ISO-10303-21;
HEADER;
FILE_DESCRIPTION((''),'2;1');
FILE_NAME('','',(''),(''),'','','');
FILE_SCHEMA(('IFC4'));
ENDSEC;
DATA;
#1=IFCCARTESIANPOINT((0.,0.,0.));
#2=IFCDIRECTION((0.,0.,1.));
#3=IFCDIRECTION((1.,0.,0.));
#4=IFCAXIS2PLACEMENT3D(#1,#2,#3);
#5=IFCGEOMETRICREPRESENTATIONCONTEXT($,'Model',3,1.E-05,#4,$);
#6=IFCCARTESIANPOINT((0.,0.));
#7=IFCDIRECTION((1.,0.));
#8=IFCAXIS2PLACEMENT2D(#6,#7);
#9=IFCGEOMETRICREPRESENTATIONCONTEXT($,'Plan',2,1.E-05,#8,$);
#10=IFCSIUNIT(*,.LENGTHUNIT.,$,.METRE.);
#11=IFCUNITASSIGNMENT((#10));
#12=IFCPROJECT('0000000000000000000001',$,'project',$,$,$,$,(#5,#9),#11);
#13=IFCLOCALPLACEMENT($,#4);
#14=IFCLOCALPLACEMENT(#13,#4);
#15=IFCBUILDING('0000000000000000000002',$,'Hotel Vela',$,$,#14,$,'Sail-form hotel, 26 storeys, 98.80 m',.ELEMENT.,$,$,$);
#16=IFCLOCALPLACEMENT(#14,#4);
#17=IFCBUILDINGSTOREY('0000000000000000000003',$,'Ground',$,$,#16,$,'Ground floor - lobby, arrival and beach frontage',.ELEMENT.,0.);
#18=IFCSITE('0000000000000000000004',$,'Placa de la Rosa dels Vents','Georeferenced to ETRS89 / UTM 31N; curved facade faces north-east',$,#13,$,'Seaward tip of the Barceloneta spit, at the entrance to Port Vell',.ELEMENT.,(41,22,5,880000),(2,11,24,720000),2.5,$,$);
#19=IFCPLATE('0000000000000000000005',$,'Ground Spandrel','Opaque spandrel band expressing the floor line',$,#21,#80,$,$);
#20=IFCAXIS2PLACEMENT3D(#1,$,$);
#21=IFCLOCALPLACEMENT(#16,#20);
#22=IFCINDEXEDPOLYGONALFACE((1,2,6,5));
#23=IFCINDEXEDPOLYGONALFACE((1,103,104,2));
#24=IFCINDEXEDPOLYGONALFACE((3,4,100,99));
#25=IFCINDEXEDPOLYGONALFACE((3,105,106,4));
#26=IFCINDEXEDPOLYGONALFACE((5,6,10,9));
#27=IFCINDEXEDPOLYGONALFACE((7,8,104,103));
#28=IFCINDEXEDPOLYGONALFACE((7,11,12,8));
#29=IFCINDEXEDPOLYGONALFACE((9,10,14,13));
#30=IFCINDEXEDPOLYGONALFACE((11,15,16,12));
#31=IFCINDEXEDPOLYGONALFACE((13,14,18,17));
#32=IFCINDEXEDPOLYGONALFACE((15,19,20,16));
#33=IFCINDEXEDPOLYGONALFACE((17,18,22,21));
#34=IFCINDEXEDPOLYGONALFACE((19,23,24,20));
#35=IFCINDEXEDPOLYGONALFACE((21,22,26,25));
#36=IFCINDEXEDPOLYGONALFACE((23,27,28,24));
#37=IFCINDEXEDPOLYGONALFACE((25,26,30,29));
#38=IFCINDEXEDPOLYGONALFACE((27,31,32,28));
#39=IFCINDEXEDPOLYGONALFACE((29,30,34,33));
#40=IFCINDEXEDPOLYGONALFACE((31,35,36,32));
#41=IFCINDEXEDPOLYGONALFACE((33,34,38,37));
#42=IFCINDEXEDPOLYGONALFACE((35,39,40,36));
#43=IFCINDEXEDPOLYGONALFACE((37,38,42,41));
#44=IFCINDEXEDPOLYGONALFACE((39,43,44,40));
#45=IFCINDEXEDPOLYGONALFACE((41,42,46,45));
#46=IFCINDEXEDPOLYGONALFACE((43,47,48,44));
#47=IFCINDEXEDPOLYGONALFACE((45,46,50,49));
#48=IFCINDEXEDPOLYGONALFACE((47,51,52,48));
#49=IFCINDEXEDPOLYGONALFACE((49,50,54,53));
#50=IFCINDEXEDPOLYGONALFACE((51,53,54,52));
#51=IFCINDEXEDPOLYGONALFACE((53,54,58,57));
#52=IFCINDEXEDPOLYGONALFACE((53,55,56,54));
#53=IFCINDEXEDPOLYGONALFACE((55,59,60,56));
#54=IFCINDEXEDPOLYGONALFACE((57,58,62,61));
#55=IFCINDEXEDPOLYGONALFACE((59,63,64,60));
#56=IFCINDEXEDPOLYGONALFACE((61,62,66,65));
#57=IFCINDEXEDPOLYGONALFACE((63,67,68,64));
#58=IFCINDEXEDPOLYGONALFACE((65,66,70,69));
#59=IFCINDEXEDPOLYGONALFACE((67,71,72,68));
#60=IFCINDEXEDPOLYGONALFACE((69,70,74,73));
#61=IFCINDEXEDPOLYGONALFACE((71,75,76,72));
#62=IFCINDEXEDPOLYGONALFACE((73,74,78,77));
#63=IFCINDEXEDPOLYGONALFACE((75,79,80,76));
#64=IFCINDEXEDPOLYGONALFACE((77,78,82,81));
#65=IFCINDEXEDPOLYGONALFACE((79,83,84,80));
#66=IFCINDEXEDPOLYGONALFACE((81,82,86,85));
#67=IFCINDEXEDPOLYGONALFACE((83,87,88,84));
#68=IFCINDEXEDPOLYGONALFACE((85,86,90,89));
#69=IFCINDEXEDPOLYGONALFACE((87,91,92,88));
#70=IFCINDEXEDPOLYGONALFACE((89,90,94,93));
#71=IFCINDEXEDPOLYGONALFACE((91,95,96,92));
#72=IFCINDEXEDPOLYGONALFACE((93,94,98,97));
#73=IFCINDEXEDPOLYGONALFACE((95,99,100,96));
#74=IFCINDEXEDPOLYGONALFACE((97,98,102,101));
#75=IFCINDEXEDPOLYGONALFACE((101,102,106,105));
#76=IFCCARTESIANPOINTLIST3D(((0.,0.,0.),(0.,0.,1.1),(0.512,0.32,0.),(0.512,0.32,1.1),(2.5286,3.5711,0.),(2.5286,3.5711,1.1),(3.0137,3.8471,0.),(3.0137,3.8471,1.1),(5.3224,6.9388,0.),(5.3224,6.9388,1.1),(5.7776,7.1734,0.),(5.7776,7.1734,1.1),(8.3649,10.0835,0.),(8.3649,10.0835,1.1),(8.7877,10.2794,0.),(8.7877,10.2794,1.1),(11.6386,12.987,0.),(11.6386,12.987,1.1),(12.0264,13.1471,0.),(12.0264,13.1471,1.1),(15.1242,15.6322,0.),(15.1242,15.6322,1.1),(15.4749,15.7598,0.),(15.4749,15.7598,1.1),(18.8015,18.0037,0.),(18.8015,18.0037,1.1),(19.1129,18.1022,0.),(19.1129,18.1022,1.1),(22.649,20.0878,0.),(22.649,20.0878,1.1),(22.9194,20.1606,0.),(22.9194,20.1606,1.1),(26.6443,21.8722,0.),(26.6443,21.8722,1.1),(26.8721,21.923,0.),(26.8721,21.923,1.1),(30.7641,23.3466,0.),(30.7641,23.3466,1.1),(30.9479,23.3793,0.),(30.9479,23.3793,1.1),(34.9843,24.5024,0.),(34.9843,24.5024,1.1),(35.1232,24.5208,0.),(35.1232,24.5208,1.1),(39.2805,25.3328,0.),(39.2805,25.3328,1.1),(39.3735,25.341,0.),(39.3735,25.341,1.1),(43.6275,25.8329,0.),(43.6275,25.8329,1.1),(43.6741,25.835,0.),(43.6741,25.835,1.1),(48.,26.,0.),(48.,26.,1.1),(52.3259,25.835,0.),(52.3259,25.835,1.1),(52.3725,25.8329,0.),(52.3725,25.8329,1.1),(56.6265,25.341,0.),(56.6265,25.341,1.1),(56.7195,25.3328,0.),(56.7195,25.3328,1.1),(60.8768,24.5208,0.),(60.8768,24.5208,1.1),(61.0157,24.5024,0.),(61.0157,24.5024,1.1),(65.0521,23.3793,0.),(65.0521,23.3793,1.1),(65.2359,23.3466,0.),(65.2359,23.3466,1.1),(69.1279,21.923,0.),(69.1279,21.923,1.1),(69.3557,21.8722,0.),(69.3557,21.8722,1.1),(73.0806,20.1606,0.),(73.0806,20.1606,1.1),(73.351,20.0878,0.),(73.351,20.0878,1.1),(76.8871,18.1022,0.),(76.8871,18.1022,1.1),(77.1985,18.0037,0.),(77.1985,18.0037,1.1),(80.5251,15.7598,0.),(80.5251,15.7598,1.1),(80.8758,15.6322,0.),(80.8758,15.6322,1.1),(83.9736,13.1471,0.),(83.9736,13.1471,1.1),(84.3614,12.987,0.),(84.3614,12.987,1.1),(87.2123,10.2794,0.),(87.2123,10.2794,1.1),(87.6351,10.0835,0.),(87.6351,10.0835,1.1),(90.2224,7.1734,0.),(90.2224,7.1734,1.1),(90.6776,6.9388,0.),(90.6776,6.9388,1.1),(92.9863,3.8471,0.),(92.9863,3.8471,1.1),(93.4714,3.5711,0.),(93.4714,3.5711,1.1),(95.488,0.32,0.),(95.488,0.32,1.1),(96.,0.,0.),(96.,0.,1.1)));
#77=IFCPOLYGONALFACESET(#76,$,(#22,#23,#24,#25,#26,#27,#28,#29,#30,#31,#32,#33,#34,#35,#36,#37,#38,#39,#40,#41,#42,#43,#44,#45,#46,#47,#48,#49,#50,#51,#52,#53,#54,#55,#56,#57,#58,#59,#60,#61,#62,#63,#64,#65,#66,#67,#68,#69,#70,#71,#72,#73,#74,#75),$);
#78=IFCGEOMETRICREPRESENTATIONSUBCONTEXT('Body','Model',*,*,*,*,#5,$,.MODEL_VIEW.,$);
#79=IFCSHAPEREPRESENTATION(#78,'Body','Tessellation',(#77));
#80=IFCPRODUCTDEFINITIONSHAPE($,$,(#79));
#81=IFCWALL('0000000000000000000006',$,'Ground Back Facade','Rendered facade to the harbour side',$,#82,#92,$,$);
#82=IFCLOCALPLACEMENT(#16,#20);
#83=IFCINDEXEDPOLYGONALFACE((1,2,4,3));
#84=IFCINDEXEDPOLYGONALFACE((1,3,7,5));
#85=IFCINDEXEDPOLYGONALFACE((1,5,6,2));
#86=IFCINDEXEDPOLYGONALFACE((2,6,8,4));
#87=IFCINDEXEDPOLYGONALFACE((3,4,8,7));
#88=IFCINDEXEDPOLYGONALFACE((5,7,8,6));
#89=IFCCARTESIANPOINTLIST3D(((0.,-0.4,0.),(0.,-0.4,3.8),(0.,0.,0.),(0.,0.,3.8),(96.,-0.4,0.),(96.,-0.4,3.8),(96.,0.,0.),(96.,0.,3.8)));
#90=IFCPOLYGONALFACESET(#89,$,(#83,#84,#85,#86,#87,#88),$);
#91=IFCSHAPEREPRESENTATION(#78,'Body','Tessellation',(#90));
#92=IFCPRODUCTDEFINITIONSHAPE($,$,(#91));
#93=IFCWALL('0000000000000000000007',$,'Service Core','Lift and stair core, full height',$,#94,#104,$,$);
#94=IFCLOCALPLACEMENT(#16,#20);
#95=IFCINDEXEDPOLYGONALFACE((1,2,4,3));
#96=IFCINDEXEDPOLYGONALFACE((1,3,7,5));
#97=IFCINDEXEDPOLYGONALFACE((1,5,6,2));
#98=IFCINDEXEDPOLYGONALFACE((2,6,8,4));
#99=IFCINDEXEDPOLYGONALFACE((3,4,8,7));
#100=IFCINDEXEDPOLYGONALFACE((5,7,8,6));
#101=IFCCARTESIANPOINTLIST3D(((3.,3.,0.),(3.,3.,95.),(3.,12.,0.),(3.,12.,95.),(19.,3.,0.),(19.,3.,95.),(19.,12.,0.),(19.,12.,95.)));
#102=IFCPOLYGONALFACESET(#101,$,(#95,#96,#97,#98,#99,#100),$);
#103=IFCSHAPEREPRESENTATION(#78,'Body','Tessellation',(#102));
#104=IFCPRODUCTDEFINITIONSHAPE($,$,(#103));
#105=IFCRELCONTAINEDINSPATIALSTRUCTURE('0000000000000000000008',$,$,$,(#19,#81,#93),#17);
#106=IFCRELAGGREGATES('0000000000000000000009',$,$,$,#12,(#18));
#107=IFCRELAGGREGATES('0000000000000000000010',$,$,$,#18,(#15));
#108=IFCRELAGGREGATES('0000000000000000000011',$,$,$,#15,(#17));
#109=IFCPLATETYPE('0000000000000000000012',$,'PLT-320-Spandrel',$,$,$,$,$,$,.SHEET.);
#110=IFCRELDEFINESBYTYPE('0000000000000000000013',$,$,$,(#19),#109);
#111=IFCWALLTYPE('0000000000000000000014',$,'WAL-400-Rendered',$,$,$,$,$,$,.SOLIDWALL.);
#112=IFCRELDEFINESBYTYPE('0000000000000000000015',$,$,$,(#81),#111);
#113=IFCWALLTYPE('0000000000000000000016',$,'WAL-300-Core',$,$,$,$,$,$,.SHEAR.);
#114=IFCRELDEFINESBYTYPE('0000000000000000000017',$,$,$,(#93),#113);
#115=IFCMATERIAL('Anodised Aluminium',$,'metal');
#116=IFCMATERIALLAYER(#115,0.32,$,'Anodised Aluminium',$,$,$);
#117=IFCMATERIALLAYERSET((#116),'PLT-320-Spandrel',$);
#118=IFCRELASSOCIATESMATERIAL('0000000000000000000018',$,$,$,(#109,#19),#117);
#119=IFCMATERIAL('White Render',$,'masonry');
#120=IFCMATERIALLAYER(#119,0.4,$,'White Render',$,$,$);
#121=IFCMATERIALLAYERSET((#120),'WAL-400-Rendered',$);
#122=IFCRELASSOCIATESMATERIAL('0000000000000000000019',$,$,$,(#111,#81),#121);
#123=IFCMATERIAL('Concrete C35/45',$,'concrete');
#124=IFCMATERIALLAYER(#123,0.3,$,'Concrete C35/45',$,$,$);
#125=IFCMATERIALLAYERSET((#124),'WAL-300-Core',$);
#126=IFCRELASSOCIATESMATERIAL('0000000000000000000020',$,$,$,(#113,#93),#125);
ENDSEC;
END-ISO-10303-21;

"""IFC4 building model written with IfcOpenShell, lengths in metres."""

from ifc_helpers import new_model, si_unit, frame, origin_with_axes, origin_2d_with_axis, place, context, subcontext, project, spatial, line, indexed_curve, outline, extrude, material, layer, layer_set, layer_usage, type_object, element, save


model = new_model("IFC4")

# Units and contexts
model_context = context("Model", 3, precision=1e-05, world=origin_with_axes())
plan_context = context("Plan", 2, precision=1e-05, world=origin_2d_with_axis())
body_context = subcontext(model_context, "Body", "Model", "MODEL_VIEW")
ifc_project = project(units=[si_unit("LENGTHUNIT", "METRE")], contexts=[model_context, plan_context])

# Site, building, storey
site_placement = place(None, origin_with_axes())
site = spatial("IfcSite", under=ifc_project, at=site_placement, Name="Placa de la Rosa dels Vents", Description="Georeferenced to ETRS89 / UTM 31N; curved facade faces north-east", LongName="Seaward tip of the Barceloneta spit, at the entrance to Port Vell", CompositionType="ELEMENT", RefLatitude=(41, 22, 5, 880000), RefLongitude=(2, 11, 24, 720000), RefElevation=2.5)
building_placement = place(site_placement, origin_with_axes())
building = spatial("IfcBuilding", under=site, at=building_placement, Name="Hotel Vela", LongName="Sail-form hotel, 26 storeys, 98.80 m", CompositionType="ELEMENT")
storey_placement = place(building_placement, origin_with_axes())
storey = spatial("IfcBuildingStorey", under=building, at=storey_placement, Name="Ground", LongName="Ground floor - lobby, arrival and beach frontage", CompositionType="ELEMENT", Elevation=0.0)

# Shared definitions
ifc_material_1 = material(Name="Concrete C35/45", Category="concrete")

# Plate
ifc_material_2 = material(Name="Anodised Aluminium", Category="metal")
ifc_layer_1 = layer(ifc_material_2, 0.32, Name="Anodised Aluminium")
ifc_layer_set_1 = layer_set([ifc_layer_1], Name="PLT-320-Spandrel")
ifc_layer_usage_1 = layer_usage(ifc_layer_set_1, "AXIS2", "POSITIVE", 0.0)
plate_type_1 = type_object("IfcPlateType", Name="PLT-320-Spandrel", PredefinedType="SHEET", material=ifc_layer_set_1)
plate_1_placement = place(storey_placement, origin_with_axes())
element("IfcPlate", 1, at=plate_1_placement, inside=storey, type_object=plate_type_1, material=ifc_layer_usage_1, Name="Ground Spandrel", Description="Opaque spandrel band expressing the floor line", context=body_context, shape_type="SweptSolid", body=[
    extrude(outline(indexed_curve([(96.0, 0.0), (93.4714, 3.5711), (90.6776, 6.9388), (87.6351, 10.0835), (84.3614, 12.987), (80.8758, 15.6322), (77.1985, 18.0037), (73.351, 20.0878), (69.3557, 21.8722), (65.2359, 23.3466), (61.0157, 24.5024), (56.7195, 25.3328), (52.3725, 25.8329), (48.0, 26.0), (43.6275, 25.8329), (39.2805, 25.3328), (34.9843, 24.5024), (30.7641, 23.3466), (26.6443, 21.8722), (22.649, 20.0878), (18.8015, 18.0037), (15.1242, 15.6322), (11.6386, 12.987), (8.3649, 10.0835), (5.3224, 6.9388), (2.5286, 3.5711), (0.0, 0.0), (95.488, 0.32), (3.0137, 3.8471), (5.7776, 7.1734), (8.7877, 10.2794), (12.0264, 13.1471), (15.4749, 15.7598), (19.1129, 18.1022), (22.9194, 20.1606), (26.8721, 21.923), (30.9479, 23.3793), (35.1232, 24.5208), (39.3735, 25.341), (43.6741, 25.835), (48.0, 26.0), (52.3259, 25.835), (56.6265, 25.341), (60.8768, 24.5208), (65.0521, 23.3793), (69.1279, 21.923), (73.0806, 20.1606), (76.8871, 18.1022), (80.5251, 15.7598), (83.9736, 13.1471), (87.2123, 10.2794), (90.2224, 7.1734), (92.9863, 3.8471), (0.512, 0.32)], segments=[line(1, 2, 3, 4, 5, 6, 7, 8, 9, 10, 11, 12, 13, 14, 15, 16, 17, 18, 19, 20, 21, 22, 23, 24, 25, 26, 27, 28, 29, 30, 31, 32, 33, 34, 35, 36, 37, 38, 39, 40, 41, 42, 43, 44, 45, 46, 47, 48, 49, 50, 51, 52, 53, 54, 1)])), origin_with_axes(), (0.0, 0.0, 1.0), 1.1),
])

# Walls
ifc_material_3 = material(Name="White Render", Category="masonry")
ifc_layer_2 = layer(ifc_material_3, 0.4, Name="White Render")
ifc_layer_set_2 = layer_set([ifc_layer_2], Name="WAL-400-Rendered")
ifc_layer_usage_2 = layer_usage(ifc_layer_set_2, "AXIS2", "POSITIVE", 0.0)
wall_type_1 = type_object("IfcWallType", Name="WAL-400-Rendered", PredefinedType="SOLIDWALL", material=ifc_layer_set_2)
wall_1_placement = place(storey_placement, frame((0.0, -0.4, 0.0), z_axis=(0.0, 0.0, 1.0), x_axis=(1.0, 0.0, 0.0)))
element("IfcWall", 2, at=wall_1_placement, inside=storey, type_object=wall_type_1, material=ifc_layer_usage_2, Name="Ground Back Facade", Description="Rendered facade to the harbour side", context=body_context, shape_type="SweptSolid", body=[
    extrude(outline(indexed_curve([(0.0, 0.0), (96.0, 0.0), (96.0, 0.4), (0.0, 0.4)], segments=[line(1, 2, 3, 4, 1)])), origin_with_axes(), (0.0, 0.0, 1.0), 3.8),
])
ifc_layer_3 = layer(ifc_material_1, 0.3, Name="Concrete C35/45")
ifc_layer_set_3 = layer_set([ifc_layer_3], Name="WAL-300-Core")
ifc_layer_usage_3 = layer_usage(ifc_layer_set_3, "AXIS2", "POSITIVE", 0.0)
wall_type_2 = type_object("IfcWallType", Name="WAL-300-Core", PredefinedType="SHEAR", material=ifc_layer_set_3)
wall_2_placement = place(storey_placement, frame((3.0, 3.0, 0.0), z_axis=(0.0, 0.0, 1.0), x_axis=(1.0, 0.0, 0.0)))
element("IfcWall", 3, at=wall_2_placement, inside=storey, type_object=wall_type_2, material=ifc_layer_usage_3, Name="Service Core", Description="Lift and stair core, full height", context=body_context, shape_type="SweptSolid", body=[
    extrude(outline(indexed_curve([(0.0, 0.0), (16.0, 0.0), (16.0, 9.0), (0.0, 9.0)], segments=[line(1, 2, 3, 4, 1)])), origin_with_axes(), (0.0, 0.0, 1.0), 95.0),
])

save(model, "model.ifc")
